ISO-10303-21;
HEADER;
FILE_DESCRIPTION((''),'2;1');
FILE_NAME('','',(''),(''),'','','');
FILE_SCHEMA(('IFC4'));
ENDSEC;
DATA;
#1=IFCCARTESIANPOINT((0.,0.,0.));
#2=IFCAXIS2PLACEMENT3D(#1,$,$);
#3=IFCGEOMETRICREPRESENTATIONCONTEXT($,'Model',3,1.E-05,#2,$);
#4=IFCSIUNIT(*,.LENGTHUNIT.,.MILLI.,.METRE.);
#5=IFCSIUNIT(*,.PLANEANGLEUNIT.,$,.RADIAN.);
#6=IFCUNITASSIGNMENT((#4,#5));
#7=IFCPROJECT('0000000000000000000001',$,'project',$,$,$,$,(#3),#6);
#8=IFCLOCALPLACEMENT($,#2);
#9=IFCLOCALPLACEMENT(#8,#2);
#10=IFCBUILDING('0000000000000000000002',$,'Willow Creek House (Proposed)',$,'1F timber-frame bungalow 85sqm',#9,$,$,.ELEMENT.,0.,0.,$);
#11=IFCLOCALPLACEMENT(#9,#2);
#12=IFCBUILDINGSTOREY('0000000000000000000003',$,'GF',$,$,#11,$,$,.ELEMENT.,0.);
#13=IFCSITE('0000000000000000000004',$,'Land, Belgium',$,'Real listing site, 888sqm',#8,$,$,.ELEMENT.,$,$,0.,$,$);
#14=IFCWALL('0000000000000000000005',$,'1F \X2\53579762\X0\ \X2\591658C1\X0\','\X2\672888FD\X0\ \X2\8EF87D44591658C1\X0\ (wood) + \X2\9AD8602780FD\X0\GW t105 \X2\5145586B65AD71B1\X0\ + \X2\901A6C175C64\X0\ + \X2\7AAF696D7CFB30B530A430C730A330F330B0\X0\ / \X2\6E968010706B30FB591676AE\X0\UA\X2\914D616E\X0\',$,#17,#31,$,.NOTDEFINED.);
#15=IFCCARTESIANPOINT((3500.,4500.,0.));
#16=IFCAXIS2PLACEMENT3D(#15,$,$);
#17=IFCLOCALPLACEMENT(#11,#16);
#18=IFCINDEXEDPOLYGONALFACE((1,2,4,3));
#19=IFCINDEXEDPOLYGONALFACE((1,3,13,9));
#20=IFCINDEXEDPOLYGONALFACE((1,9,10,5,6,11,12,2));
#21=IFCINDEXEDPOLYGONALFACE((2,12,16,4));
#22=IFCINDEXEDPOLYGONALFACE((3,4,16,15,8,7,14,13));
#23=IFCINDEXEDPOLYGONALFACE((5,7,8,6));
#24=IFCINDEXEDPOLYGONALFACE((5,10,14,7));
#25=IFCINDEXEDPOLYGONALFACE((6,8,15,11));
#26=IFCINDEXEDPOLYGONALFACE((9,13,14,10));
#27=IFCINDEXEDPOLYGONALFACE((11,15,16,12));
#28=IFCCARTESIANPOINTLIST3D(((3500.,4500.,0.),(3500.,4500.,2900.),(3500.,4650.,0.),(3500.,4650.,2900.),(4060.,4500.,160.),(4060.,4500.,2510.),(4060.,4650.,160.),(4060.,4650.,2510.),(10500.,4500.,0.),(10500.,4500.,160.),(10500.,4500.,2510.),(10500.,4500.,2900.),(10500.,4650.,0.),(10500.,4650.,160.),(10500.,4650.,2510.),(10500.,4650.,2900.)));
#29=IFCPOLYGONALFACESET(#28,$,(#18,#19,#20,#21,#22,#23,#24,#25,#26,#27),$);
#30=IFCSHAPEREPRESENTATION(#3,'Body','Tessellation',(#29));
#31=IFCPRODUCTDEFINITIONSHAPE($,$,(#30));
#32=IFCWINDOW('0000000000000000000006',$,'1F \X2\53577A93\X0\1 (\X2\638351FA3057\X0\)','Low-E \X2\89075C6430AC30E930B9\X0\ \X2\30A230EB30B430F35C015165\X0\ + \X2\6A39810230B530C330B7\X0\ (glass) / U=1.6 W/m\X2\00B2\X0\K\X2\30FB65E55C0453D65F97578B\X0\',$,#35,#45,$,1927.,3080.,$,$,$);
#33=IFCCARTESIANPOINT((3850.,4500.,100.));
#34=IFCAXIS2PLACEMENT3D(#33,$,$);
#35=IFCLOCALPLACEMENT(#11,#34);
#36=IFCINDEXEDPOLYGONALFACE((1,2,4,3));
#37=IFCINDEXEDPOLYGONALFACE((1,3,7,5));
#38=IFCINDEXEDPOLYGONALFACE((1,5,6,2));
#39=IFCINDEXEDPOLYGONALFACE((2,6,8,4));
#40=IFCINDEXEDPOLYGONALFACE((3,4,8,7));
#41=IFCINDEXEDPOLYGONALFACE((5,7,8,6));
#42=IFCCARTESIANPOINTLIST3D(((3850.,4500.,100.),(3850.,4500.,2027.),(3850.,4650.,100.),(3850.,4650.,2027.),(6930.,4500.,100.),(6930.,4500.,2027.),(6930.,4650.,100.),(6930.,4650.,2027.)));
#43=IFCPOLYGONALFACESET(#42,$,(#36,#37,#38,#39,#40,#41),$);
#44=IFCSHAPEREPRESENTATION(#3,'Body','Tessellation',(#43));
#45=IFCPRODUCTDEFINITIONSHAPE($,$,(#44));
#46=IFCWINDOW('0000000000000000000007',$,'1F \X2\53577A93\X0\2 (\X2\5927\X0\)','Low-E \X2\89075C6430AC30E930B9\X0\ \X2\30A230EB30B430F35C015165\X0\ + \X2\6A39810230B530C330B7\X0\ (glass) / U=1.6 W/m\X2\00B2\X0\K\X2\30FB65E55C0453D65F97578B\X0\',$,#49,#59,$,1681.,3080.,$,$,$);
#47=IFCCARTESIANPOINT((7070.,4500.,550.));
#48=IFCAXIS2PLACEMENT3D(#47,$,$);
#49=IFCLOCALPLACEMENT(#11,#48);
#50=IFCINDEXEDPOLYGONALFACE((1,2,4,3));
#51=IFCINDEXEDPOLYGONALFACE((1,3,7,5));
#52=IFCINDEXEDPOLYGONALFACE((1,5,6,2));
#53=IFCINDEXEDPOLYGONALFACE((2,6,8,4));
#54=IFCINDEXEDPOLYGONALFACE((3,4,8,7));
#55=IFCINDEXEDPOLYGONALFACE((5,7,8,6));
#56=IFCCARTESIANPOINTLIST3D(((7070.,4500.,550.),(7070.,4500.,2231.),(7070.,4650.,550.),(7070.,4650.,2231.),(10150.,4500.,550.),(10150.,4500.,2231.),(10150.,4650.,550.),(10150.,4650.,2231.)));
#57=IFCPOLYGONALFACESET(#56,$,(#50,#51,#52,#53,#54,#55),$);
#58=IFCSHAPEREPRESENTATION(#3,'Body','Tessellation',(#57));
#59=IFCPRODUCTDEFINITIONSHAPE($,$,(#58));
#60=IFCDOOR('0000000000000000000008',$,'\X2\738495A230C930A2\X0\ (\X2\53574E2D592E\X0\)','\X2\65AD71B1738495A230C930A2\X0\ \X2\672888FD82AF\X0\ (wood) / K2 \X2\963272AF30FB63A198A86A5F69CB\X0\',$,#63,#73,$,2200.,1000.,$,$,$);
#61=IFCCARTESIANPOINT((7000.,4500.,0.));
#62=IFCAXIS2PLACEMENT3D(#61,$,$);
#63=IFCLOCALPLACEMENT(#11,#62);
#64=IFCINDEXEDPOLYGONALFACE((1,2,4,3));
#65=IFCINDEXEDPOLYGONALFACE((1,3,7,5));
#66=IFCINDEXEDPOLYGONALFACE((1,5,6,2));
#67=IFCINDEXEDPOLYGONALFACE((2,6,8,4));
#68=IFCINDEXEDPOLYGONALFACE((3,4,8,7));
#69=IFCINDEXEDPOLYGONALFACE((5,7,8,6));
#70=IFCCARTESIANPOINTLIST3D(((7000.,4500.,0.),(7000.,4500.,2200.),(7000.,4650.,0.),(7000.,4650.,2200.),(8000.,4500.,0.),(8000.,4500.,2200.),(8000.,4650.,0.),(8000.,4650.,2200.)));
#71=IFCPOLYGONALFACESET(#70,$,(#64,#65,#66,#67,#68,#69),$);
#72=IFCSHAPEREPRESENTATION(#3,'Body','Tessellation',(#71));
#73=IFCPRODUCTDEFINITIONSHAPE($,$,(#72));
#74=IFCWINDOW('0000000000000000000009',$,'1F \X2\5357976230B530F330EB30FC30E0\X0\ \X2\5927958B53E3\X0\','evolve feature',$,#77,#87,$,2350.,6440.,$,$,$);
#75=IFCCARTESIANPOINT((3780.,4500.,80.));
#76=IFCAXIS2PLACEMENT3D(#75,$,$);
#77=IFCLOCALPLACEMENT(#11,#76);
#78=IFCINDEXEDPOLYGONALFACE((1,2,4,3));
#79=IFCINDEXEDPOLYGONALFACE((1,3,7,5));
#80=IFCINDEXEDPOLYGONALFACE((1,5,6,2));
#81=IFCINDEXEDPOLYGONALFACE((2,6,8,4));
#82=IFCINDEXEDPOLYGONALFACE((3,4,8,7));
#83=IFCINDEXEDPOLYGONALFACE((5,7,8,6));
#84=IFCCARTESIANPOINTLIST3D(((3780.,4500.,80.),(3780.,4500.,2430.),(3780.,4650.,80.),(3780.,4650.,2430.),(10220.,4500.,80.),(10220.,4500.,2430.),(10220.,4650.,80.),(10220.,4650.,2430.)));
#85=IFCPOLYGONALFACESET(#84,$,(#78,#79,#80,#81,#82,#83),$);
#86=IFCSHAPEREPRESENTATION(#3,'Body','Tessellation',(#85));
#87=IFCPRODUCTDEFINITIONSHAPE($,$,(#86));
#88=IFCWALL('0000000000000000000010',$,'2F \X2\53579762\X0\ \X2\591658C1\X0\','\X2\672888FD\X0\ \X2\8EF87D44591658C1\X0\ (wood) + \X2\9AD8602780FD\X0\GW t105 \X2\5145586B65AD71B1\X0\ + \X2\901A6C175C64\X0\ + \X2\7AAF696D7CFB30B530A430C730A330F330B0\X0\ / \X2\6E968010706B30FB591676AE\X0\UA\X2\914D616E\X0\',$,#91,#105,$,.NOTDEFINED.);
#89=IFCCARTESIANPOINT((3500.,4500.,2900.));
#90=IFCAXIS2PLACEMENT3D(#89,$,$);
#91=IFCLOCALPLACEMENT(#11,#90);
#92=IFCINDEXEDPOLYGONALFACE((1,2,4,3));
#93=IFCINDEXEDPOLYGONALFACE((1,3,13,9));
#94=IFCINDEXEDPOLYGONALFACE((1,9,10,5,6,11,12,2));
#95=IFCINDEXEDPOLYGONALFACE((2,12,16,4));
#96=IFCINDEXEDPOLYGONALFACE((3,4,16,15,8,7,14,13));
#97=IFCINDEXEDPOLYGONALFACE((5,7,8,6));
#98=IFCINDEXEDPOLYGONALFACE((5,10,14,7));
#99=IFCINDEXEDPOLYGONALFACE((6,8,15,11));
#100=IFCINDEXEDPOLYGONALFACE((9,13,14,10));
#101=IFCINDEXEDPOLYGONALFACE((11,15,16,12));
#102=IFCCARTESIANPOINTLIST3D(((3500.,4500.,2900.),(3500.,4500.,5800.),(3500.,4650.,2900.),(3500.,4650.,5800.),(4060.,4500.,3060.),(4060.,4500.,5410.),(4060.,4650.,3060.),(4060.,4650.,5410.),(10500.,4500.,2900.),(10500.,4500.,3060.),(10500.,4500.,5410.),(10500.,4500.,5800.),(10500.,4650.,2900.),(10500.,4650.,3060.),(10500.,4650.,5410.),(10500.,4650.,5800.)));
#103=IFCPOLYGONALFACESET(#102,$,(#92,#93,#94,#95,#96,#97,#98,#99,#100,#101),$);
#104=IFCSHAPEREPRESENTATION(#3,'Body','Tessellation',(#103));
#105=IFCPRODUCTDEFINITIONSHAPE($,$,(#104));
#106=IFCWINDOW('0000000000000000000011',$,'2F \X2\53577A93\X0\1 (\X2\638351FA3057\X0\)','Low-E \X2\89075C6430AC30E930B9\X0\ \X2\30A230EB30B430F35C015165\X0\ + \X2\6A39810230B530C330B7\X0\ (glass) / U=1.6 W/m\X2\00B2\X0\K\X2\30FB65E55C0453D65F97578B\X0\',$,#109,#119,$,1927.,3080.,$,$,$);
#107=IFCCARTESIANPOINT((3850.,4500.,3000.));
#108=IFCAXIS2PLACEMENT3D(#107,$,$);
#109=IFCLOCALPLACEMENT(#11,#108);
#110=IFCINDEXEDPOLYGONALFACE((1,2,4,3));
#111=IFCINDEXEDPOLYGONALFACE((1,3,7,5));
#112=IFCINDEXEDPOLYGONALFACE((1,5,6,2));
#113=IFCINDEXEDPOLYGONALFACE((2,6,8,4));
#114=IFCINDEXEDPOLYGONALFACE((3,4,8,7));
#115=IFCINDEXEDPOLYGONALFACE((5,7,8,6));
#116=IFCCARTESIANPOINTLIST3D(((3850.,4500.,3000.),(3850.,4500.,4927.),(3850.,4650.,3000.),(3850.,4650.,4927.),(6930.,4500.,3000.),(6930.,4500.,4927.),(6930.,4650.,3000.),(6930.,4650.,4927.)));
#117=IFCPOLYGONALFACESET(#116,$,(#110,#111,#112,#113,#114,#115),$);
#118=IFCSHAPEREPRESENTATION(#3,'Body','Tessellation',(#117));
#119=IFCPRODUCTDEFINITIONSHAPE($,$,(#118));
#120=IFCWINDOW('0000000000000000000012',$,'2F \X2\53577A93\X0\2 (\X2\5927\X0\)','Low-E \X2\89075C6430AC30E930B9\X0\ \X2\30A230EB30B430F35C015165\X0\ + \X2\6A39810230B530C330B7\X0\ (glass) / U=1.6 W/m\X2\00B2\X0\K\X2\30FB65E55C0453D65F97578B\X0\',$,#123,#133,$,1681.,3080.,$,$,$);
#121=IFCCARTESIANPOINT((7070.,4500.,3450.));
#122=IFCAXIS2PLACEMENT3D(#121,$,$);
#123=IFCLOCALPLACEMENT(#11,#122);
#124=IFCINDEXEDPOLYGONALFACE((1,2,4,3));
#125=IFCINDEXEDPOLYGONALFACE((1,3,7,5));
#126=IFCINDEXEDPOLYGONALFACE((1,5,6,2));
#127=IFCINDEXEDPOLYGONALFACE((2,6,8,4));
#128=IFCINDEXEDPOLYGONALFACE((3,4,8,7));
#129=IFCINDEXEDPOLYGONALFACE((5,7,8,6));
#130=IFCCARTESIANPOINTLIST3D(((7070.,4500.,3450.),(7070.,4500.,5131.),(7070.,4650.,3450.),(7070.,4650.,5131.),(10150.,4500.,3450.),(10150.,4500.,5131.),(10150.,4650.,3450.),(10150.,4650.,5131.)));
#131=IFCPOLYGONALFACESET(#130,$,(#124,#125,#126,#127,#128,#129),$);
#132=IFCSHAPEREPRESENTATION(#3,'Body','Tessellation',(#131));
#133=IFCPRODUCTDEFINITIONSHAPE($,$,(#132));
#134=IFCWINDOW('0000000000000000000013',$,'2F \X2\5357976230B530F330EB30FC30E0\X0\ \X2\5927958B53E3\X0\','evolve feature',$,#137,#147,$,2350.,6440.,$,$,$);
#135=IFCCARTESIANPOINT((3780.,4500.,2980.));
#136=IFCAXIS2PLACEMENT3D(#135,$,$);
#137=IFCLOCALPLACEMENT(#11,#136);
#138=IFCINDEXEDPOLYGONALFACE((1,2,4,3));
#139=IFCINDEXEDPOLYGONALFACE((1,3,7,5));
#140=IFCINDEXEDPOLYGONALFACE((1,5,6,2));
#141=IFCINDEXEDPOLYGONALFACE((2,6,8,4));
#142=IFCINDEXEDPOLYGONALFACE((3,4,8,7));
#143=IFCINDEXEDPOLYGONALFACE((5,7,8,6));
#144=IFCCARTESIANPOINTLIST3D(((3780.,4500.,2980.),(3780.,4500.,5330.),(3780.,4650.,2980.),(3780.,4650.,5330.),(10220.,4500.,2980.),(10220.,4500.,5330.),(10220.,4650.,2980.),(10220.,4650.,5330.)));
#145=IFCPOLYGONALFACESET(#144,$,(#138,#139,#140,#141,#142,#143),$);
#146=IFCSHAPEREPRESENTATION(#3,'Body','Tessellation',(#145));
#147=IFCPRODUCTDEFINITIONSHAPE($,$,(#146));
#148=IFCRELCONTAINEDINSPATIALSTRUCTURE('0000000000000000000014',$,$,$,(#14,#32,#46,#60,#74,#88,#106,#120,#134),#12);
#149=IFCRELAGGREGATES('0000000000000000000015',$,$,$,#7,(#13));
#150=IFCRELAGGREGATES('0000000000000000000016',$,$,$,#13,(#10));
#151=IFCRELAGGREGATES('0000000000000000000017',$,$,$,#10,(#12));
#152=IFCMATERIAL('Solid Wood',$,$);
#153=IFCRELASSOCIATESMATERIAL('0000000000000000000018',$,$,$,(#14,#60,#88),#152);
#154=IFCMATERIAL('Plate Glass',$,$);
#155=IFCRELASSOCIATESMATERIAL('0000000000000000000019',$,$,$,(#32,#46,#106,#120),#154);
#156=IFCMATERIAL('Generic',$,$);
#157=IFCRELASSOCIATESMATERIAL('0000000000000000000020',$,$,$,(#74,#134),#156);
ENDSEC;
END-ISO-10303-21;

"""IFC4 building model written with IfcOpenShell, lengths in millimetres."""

from ifc_helpers import new_model, si_unit, frame, frame_2d, origin, place, context, project, spatial, rectangle, extrude, material, element, fill, save


model = new_model("IFC4")

# Units and contexts
model_context = context("Model", 3, precision=1e-05, world=origin())
ifc_project = project(units=[si_unit("LENGTHUNIT", "METRE", prefix="MILLI"), si_unit("PLANEANGLEUNIT", "RADIAN")], contexts=[model_context])

# Site, building, storey
site_placement = place(None, origin())
site = spatial("IfcSite", under=ifc_project, at=site_placement, Name="Land, Belgium", ObjectType="Real listing site, 888sqm", CompositionType="ELEMENT", RefElevation=0.0)
building_placement = place(site_placement, origin())
building = spatial("IfcBuilding", under=site, at=building_placement, Name="Willow Creek House (Proposed)", ObjectType="1F timber-frame bungalow 85sqm", CompositionType="ELEMENT", ElevationOfRefHeight=0.0, ElevationOfTerrain=0.0)
storey_placement = place(building_placement, origin())
storey = spatial("IfcBuildingStorey", under=building, at=storey_placement, Name="GF", CompositionType="ELEMENT", Elevation=0.0)

# Shared definitions
ifc_material_1 = material(Name="Solid Wood")
ifc_material_2 = material(Name="Generic")

# Wall, openings, windows, door
wall_1_placement = place(storey_placement, frame((3500.0, 4500.0, 0.0)))
wall_1 = element("IfcWall", 1, at=wall_1_placement, inside=storey, material=ifc_material_1, Name="1F 南面 外壁", Description="木製 軸組外壁 (wood) + 高性能GW t105 充填断熱 + 通気層 + 窯業系サイディング / 準耐火・外皮UA配慮", PredefinedType="NOTDEFINED", context=model_context, shape_type="SweptSolid", body=[
    extrude(rectangle(XDim=7000.0, YDim=150.0, at=frame_2d((3500.0, 75.0))), frame((3500.0, 4500.0, 0.0)), (0.0, 0.0, 1.0), 2900.0),
])
opening_1_placement = place(storey_placement, frame((3850.0, 4500.0, 100.0)))
opening_1 = element("IfcOpeningElement", 2, at=opening_1_placement, cuts=wall_1, PredefinedType="NOTDEFINED", context=model_context, shape_type="SweptSolid", body=[
    extrude(rectangle(XDim=3080.0, YDim=150.0, at=frame_2d((1540.0, 75.0))), frame((3850.0, 4500.0, 100.0)), (0.0, 0.0, 1.0), 1927.0),
])
opening_2_placement = place(storey_placement, frame((7070.0, 4500.0, 550.0)))
opening_2 = element("IfcOpeningElement", 3, at=opening_2_placement, cuts=wall_1, PredefinedType="NOTDEFINED", context=model_context, shape_type="SweptSolid", body=[
    extrude(rectangle(XDim=3080.0, YDim=150.0, at=frame_2d((1540.0, 75.0))), frame((7070.0, 4500.0, 550.0)), (0.0, 0.0, 1.0), 1681.0),
])
opening_3_placement = place(storey_placement, frame((7000.0, 4500.0, 0.0)))
opening_3 = element("IfcOpeningElement", 4, at=opening_3_placement, cuts=wall_1, PredefinedType="NOTDEFINED", context=model_context, shape_type="SweptSolid", body=[
    extrude(rectangle(XDim=1000.0, YDim=150.0, at=frame_2d((500.0, 75.0))), frame((7000.0, 4500.0, 0.0)), (0.0, 0.0, 1.0), 2200.0),
])
opening_4_placement = place(storey_placement, frame((3780.0, 4500.0, 80.0)))
opening_4 = element("IfcOpeningElement", 5, at=opening_4_placement, cuts=wall_1, PredefinedType="NOTDEFINED", context=model_context, shape_type="SweptSolid", body=[
    extrude(rectangle(XDim=6440.0, YDim=150.0, at=frame_2d((3220.0, 75.0))), frame((3780.0, 4500.0, 80.0)), (0.0, 0.0, 1.0), 2350.0),
])
ifc_material_3 = material(Name="Plate Glass")
window_1_placement = place(storey_placement, frame((3850.0, 4500.0, 100.0)))
window_1 = element("IfcWindow", 6, at=window_1_placement, inside=storey, material=ifc_material_3, Name="1F 南窓1 (掃出し)", Description="Low-E 複層ガラス アルゴン封入 + 樹脂サッシ (glass) / U=1.6 W/m²K・日射取得型", OverallHeight=1927.0, OverallWidth=3080.0, context=model_context, shape_type="SweptSolid", body=[
    extrude(rectangle(XDim=3080.0, YDim=150.0, at=frame_2d((1540.0, 75.0))), frame((3850.0, 4500.0, 100.0)), (0.0, 0.0, 1.0), 1927.0),
])
fill(opening_1, window_1)
window_2_placement = place(storey_placement, frame((7070.0, 4500.0, 550.0)))
window_2 = element("IfcWindow", 7, at=window_2_placement, inside=storey, material=ifc_material_3, Name="1F 南窓2 (大)", Description="Low-E 複層ガラス アルゴン封入 + 樹脂サッシ (glass) / U=1.6 W/m²K・日射取得型", OverallHeight=1681.0, OverallWidth=3080.0, context=model_context, shape_type="SweptSolid", body=[
    extrude(rectangle(XDim=3080.0, YDim=150.0, at=frame_2d((1540.0, 75.0))), frame((7070.0, 4500.0, 550.0)), (0.0, 0.0, 1.0), 1681.0),
])
fill(opening_2, window_2)
door_placement = place(storey_placement, frame((7000.0, 4500.0, 0.0)))
door = element("IfcDoor", 8, at=door_placement, inside=storey, material=ifc_material_1, Name="玄関ドア (南中央)", Description="断熱玄関ドア 木製芯 (wood) / K2 防犯・採風機構", OverallHeight=2200.0, OverallWidth=1000.0, context=model_context, shape_type="SweptSolid", body=[
    extrude(rectangle(XDim=1000.0, YDim=150.0, at=frame_2d((500.0, 75.0))), frame((7000.0, 4500.0, 0.0)), (0.0, 0.0, 1.0), 2200.0),
])
fill(opening_3, door)
window_3_placement = place(storey_placement, frame((3780.0, 4500.0, 80.0)))
window_3 = element("IfcWindow", 9, at=window_3_placement, inside=storey, material=ifc_material_2, Name="1F 南面サンルーム 大開口", Description="evolve feature", OverallHeight=2350.0, OverallWidth=6440.0, context=model_context, shape_type="SweptSolid", body=[
    extrude(rectangle(XDim=6440.0, YDim=150.0, at=frame_2d((3220.0, 75.0))), frame((3780.0, 4500.0, 80.0)), (0.0, 0.0, 1.0), 2350.0),
])
fill(opening_4, window_3)

# Wall, openings, windows
wall_2_placement = place(storey_placement, frame((3500.0, 4500.0, 2900.0)))
wall_2 = element("IfcWall", 10, at=wall_2_placement, inside=storey, material=ifc_material_1, Name="2F 南面 外壁", Description="木製 軸組外壁 (wood) + 高性能GW t105 充填断熱 + 通気層 + 窯業系サイディング / 準耐火・外皮UA配慮", PredefinedType="NOTDEFINED", context=model_context, shape_type="SweptSolid", body=[
    extrude(rectangle(XDim=7000.0, YDim=150.0, at=frame_2d((3500.0, 75.0))), frame((3500.0, 4500.0, 2900.0)), (0.0, 0.0, 1.0), 2900.0),
])
opening_5_placement = place(storey_placement, frame((3850.0, 4500.0, 3000.0)))
opening_5 = element("IfcOpeningElement", 11, at=opening_5_placement, cuts=wall_2, PredefinedType="NOTDEFINED", context=model_context, shape_type="SweptSolid", body=[
    extrude(rectangle(XDim=3080.0, YDim=150.0, at=frame_2d((1540.0, 75.0))), frame((3850.0, 4500.0, 3000.0)), (0.0, 0.0, 1.0), 1927.0),
])
opening_6_placement = place(storey_placement, frame((7070.0, 4500.0, 3450.0)))
opening_6 = element("IfcOpeningElement", 12, at=opening_6_placement, cuts=wall_2, PredefinedType="NOTDEFINED", context=model_context, shape_type="SweptSolid", body=[
    extrude(rectangle(XDim=3080.0, YDim=150.0, at=frame_2d((1540.0, 75.0))), frame((7070.0, 4500.0, 3450.0)), (0.0, 0.0, 1.0), 1681.0),
])
opening_7_placement = place(storey_placement, frame((3780.0, 4500.0, 2980.0)))
opening_7 = element("IfcOpeningElement", 13, at=opening_7_placement, cuts=wall_2, PredefinedType="NOTDEFINED", context=model_context, shape_type="SweptSolid", body=[
    extrude(rectangle(XDim=6440.0, YDim=150.0, at=frame_2d((3220.0, 75.0))), frame((3780.0, 4500.0, 2980.0)), (0.0, 0.0, 1.0), 2350.0),
])
window_4_placement = place(storey_placement, frame((3850.0, 4500.0, 3000.0)))
window_4 = element("IfcWindow", 14, at=window_4_placement, inside=storey, material=ifc_material_3, Name="2F 南窓1 (掃出し)", Description="Low-E 複層ガラス アルゴン封入 + 樹脂サッシ (glass) / U=1.6 W/m²K・日射取得型", OverallHeight=1927.0, OverallWidth=3080.0, context=model_context, shape_type="SweptSolid", body=[
    extrude(rectangle(XDim=3080.0, YDim=150.0, at=frame_2d((1540.0, 75.0))), frame((3850.0, 4500.0, 3000.0)), (0.0, 0.0, 1.0), 1927.0),
])
fill(opening_5, window_4)
window_5_placement = place(storey_placement, frame((7070.0, 4500.0, 3450.0)))
window_5 = element("IfcWindow", 15, at=window_5_placement, inside=storey, material=ifc_material_3, Name="2F 南窓2 (大)", Description="Low-E 複層ガラス アルゴン封入 + 樹脂サッシ (glass) / U=1.6 W/m²K・日射取得型", OverallHeight=1681.0, OverallWidth=3080.0, context=model_context, shape_type="SweptSolid", body=[
    extrude(rectangle(XDim=3080.0, YDim=150.0, at=frame_2d((1540.0, 75.0))), frame((7070.0, 4500.0, 3450.0)), (0.0, 0.0, 1.0), 1681.0),
])
fill(opening_6, window_5)
window_6_placement = place(storey_placement, frame((3780.0, 4500.0, 2980.0)))
window_6 = element("IfcWindow", 16, at=window_6_placement, inside=storey, material=ifc_material_2, Name="2F 南面サンルーム 大開口", Description="evolve feature", OverallHeight=2350.0, OverallWidth=6440.0, context=model_context, shape_type="SweptSolid", body=[
    extrude(rectangle(XDim=6440.0, YDim=150.0, at=frame_2d((3220.0, 75.0))), frame((3780.0, 4500.0, 2980.0)), (0.0, 0.0, 1.0), 2350.0),
])
fill(opening_7, window_6)

save(model, "model.ifc")
